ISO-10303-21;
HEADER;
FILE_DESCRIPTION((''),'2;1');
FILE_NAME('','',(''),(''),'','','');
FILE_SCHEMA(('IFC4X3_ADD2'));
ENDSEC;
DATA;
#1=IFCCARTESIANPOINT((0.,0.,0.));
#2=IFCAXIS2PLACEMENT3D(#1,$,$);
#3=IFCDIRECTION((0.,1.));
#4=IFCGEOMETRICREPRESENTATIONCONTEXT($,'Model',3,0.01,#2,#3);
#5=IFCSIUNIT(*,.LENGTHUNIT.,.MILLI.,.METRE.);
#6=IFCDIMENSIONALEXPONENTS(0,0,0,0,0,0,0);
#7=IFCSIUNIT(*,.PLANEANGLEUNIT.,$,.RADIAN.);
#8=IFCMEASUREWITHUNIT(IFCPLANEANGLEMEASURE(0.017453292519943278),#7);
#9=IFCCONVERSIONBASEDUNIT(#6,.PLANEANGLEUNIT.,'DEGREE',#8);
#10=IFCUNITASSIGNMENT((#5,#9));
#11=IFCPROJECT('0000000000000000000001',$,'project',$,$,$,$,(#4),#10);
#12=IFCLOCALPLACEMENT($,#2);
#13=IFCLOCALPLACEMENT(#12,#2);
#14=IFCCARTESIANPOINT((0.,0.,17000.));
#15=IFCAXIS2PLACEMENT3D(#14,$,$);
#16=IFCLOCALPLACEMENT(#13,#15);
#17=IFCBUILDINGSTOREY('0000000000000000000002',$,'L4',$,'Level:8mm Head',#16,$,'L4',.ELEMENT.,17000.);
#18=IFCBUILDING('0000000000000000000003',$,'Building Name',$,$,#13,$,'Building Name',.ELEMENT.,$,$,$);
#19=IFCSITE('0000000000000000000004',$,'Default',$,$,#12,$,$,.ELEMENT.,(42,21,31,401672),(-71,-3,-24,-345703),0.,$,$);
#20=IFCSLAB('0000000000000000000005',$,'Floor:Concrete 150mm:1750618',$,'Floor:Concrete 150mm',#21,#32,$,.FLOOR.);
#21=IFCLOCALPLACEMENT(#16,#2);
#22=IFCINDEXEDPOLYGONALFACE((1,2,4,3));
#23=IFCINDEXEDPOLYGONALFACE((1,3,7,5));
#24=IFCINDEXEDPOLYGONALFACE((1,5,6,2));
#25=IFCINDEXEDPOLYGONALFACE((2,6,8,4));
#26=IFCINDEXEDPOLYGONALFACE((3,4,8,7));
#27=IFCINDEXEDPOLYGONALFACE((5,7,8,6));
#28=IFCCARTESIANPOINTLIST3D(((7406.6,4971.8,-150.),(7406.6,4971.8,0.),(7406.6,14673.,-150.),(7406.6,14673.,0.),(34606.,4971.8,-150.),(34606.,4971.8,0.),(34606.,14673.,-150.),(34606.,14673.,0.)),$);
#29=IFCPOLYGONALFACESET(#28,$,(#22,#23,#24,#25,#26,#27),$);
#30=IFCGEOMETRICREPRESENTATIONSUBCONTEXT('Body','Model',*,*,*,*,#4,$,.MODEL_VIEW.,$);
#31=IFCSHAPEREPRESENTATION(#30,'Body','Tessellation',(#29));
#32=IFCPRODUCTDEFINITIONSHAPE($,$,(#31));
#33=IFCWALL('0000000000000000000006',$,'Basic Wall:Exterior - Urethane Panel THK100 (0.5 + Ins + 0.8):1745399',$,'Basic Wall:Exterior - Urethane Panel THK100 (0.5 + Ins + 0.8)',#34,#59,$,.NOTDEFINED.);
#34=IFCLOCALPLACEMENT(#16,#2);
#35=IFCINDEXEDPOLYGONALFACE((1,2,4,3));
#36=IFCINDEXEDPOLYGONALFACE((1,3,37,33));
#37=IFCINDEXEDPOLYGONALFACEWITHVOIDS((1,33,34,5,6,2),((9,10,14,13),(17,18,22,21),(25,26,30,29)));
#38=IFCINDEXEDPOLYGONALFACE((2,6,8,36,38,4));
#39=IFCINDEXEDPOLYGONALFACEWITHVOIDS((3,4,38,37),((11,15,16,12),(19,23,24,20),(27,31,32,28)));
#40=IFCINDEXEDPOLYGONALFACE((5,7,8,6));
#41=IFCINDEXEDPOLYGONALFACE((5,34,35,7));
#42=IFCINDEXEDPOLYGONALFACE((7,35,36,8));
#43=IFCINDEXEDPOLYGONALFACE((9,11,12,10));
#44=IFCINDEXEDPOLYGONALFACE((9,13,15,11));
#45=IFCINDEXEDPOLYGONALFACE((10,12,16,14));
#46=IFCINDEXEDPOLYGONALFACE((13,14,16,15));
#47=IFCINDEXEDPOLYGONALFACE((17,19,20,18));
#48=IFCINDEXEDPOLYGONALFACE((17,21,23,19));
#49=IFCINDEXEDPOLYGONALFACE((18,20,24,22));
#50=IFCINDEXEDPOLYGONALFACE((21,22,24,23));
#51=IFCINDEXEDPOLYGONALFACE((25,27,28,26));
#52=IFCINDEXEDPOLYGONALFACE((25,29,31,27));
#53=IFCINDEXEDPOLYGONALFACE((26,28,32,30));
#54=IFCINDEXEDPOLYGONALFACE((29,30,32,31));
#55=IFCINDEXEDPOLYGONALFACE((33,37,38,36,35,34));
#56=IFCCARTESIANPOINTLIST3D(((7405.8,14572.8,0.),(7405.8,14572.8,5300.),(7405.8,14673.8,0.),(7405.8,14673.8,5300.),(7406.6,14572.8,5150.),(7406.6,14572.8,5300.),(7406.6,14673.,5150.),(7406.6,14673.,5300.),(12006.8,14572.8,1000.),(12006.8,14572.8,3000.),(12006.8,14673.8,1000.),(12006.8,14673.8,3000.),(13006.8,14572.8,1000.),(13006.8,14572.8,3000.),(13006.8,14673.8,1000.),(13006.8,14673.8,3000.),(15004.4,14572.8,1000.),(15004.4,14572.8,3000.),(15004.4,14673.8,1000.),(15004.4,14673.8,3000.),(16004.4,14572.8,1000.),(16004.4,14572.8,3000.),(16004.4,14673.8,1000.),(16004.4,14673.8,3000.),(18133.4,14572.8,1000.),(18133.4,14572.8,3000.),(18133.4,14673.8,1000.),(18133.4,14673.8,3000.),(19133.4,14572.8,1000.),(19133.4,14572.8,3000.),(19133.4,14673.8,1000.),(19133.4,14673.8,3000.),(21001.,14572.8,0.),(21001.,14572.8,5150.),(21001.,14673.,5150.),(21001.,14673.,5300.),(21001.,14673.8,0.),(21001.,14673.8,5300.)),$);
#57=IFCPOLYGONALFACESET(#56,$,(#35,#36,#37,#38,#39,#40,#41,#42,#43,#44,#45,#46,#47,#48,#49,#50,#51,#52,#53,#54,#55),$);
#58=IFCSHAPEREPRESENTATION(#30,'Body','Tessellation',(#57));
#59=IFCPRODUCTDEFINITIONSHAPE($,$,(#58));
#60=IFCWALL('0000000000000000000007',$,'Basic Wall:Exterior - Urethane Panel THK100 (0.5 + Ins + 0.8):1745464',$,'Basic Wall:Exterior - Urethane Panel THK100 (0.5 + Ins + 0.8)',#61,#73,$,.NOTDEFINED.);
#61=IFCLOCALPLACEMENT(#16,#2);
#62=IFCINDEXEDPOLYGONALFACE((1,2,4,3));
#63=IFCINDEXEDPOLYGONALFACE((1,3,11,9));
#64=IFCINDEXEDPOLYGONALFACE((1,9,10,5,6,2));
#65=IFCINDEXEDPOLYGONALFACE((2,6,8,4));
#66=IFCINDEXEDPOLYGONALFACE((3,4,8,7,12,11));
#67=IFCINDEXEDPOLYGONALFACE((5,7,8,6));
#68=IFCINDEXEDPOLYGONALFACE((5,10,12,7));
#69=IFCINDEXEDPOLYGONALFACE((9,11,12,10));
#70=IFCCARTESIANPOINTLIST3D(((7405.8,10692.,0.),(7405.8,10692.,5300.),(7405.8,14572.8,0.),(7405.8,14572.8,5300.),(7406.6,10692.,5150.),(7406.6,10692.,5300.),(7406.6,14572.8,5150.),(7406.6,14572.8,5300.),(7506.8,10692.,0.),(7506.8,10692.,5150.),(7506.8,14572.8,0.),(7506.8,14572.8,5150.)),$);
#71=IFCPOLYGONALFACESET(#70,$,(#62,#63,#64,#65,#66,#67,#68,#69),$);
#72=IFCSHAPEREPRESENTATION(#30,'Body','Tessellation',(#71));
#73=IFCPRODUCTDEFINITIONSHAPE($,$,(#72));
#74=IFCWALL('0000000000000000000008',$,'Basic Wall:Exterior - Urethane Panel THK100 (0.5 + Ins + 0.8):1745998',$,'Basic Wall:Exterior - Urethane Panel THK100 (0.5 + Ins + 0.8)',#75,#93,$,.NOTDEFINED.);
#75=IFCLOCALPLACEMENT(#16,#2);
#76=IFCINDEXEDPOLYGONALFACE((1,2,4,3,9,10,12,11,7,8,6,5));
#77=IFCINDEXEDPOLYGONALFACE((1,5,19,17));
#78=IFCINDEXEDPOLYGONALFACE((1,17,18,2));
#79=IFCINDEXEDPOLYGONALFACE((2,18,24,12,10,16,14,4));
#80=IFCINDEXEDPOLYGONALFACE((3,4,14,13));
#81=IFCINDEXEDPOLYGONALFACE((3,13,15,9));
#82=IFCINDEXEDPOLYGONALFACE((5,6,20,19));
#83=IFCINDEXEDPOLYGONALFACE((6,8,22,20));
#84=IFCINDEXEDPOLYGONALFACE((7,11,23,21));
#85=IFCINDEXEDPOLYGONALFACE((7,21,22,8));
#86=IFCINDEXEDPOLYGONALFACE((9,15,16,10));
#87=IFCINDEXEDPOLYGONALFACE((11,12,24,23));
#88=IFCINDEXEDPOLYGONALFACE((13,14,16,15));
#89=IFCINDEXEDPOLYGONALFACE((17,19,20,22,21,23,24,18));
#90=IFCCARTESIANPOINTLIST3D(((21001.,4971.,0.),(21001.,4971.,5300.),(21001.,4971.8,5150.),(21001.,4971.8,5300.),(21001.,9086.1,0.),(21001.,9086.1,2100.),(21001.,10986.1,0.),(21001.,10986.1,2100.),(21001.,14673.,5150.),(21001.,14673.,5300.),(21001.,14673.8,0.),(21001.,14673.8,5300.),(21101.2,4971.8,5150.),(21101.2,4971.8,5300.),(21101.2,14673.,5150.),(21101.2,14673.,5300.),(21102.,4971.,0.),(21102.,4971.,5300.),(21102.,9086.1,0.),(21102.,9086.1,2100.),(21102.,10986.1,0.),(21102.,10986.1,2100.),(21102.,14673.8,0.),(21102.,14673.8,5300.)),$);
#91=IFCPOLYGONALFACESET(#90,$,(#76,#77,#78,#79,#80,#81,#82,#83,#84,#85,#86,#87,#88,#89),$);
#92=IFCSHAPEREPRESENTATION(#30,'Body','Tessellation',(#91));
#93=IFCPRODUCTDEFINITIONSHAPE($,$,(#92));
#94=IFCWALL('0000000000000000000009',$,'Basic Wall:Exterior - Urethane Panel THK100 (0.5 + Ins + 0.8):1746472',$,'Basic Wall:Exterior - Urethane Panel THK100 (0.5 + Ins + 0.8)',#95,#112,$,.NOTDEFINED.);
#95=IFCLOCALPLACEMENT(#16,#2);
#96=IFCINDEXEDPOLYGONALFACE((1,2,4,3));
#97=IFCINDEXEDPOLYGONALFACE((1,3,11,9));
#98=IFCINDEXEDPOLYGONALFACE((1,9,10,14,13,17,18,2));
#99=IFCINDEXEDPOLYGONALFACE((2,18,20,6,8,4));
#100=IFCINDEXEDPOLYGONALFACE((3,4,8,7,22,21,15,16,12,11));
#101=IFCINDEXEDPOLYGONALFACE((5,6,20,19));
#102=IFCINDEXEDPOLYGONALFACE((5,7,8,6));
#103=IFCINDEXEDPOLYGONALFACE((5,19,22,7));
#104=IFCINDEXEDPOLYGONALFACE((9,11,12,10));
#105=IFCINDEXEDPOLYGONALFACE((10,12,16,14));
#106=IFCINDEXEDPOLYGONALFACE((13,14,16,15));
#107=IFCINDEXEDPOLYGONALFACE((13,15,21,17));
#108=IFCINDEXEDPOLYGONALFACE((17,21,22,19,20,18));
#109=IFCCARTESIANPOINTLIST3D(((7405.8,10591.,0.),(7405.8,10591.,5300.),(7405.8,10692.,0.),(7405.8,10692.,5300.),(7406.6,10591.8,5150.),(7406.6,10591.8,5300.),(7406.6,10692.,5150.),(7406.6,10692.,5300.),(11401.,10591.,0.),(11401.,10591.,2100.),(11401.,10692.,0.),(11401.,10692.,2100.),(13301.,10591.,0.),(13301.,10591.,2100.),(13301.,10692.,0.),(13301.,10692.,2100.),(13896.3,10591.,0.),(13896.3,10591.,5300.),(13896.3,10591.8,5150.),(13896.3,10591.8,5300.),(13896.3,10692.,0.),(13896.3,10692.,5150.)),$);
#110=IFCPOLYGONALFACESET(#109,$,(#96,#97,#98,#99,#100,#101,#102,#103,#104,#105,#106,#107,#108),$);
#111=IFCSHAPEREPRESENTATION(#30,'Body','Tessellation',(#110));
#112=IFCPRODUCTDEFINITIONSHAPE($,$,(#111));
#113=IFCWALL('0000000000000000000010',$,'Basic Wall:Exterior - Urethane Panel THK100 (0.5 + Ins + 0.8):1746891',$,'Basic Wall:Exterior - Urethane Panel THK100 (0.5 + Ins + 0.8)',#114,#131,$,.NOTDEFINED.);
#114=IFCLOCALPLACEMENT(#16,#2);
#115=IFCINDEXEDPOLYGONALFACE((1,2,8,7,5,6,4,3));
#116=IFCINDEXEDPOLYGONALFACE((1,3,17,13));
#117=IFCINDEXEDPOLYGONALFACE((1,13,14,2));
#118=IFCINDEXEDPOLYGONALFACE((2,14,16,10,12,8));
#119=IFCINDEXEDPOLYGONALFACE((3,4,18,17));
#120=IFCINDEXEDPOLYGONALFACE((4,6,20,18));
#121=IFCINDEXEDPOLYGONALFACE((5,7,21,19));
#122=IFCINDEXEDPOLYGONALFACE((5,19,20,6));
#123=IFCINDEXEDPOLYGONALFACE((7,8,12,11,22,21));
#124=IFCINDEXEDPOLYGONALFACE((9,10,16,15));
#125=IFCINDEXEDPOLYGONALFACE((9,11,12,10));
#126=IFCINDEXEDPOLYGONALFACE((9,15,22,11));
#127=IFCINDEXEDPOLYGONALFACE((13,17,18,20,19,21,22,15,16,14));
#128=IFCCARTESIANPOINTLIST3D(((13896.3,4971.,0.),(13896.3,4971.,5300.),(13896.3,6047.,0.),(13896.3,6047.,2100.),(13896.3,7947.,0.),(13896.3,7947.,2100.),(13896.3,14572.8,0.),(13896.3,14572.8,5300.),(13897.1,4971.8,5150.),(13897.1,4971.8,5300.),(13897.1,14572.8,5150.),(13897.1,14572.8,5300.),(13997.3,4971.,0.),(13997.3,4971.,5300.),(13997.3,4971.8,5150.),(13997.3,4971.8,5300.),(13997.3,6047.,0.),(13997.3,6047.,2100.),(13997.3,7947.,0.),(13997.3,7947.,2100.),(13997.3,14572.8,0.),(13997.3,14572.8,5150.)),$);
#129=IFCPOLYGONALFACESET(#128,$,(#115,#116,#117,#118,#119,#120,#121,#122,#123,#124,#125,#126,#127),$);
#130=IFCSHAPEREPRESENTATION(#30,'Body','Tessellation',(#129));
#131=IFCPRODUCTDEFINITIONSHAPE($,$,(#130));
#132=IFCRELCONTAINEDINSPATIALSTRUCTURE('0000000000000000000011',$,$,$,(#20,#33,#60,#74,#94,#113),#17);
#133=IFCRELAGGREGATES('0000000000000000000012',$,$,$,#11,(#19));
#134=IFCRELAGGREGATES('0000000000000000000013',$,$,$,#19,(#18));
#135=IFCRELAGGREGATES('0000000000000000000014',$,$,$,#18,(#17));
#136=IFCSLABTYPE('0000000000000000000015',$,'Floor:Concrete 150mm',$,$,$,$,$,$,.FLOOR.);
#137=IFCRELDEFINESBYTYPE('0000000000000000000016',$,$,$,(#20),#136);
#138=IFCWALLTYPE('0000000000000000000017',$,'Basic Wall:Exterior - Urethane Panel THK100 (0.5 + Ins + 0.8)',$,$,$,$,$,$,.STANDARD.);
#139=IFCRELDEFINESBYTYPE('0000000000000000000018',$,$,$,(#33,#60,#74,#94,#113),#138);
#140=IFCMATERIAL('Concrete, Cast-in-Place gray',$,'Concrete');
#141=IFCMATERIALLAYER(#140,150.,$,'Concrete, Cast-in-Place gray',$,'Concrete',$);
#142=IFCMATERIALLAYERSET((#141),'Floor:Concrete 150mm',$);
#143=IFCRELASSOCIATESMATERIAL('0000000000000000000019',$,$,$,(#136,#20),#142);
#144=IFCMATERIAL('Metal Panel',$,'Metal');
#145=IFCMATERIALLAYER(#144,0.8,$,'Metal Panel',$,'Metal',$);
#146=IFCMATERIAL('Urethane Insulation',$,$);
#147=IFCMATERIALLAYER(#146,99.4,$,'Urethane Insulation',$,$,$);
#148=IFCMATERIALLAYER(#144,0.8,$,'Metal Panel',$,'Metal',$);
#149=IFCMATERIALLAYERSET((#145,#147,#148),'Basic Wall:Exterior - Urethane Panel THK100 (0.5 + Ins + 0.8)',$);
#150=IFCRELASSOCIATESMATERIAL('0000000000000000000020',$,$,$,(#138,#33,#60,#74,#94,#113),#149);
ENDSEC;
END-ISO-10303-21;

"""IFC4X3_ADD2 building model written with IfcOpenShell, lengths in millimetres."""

from ifc_helpers import new_model, entity, si_unit, converted_unit, direction, frame, frame_2d, origin, place, context, subcontext, project, spatial, polyline, rectangle, extrude, clip, bounded_halfspace, material, layer, layer_set, layer_usage, type_object, element, save


model = new_model("IFC4X3_ADD2")

# Units and contexts
model_context = context("Model", 3, precision=0.01, world=origin(), true_north=direction((0.0, 1.0)))
body_context = subcontext(model_context, "Body", "Model", "MODEL_VIEW")
ifc_project = project(units=[si_unit("LENGTHUNIT", "METRE", prefix="MILLI"), converted_unit("PLANEANGLEUNIT", "DEGREE", entity("IfcPlaneAngleMeasure", 0.017453292519943278), si_unit("PLANEANGLEUNIT", "RADIAN"), dimensions=[0, 0, 0, 0, 0, 0, 0])], contexts=[model_context])

# Site, building, storey
site_placement = place(None, origin())
site = spatial("IfcSite", under=ifc_project, at=site_placement, Name="Default", CompositionType="ELEMENT", RefLatitude=(42, 21, 31, 401672), RefLongitude=(-71, -3, -24, -345703), RefElevation=0.0)
building_placement = place(site_placement, origin())
building = spatial("IfcBuilding", under=site, at=building_placement, Name="Building Name", LongName="Building Name", CompositionType="ELEMENT")
storey_placement = place(building_placement, frame((0.0, 0.0, 17000.0)))
storey = spatial("IfcBuildingStorey", under=building, at=storey_placement, Name="L4", ObjectType="Level:8mm Head", LongName="L4", CompositionType="ELEMENT", Elevation=17000.0)

# Slab
ifc_material_1 = material(Name="Concrete, Cast-in-Place gray", Category="Concrete")
ifc_layer_1 = layer(ifc_material_1, 150.0, Name="Concrete, Cast-in-Place gray", Category="Concrete")
ifc_layer_set_1 = layer_set([ifc_layer_1], Name="Floor:Concrete 150mm")
ifc_layer_usage = layer_usage(ifc_layer_set_1, "AXIS3", "POSITIVE", 0.0)
slab_type = type_object("IfcSlabType", Name="Floor:Concrete 150mm", PredefinedType="FLOOR", material=ifc_layer_set_1)
slab_placement = place(storey_placement, origin())
element("IfcSlab", 1, at=slab_placement, inside=storey, type_object=slab_type, material=ifc_layer_usage, Name="Floor:Concrete 150mm:1750618", ObjectType="Floor:Concrete 150mm", PredefinedType="FLOOR", context=body_context, shape_type="SweptSolid", body=[
    extrude(rectangle(XDim=9701.2, YDim=27199.4, at=frame_2d((0.0, 0.0), x_axis=(1.0, 0.0))), frame((21006.3, 9822.4, 0.0), z_axis=(0.0, 0.0, -1.0), x_axis=(0.0, 1.0, 0.0)), (0.0, 0.0, 1.0), 150.0),
])

# Wall, openings
ifc_material_2 = material(Name="Metal Panel", Category="Metal")
ifc_layer_2 = layer(ifc_material_2, 0.8, Name="Metal Panel", Category="Metal")
ifc_material_3 = material(Name="Urethane Insulation")
ifc_layer_3 = layer(ifc_material_3, 99.4, Name="Urethane Insulation")
ifc_layer_4 = layer(ifc_material_2, 0.8, Name="Metal Panel", Category="Metal")
ifc_layer_set_2 = layer_set([ifc_layer_2, ifc_layer_3, ifc_layer_4], Name="Basic Wall:Exterior - Urethane Panel THK100 (0.5 + Ins + 0.8)")
wall_type = type_object("IfcWallType", Name="Basic Wall:Exterior - Urethane Panel THK100 (0.5 + Ins + 0.8)", PredefinedType="STANDARD", material=ifc_layer_set_2)
wall_1_placement = place(storey_placement, frame((7405.8, 14623.3, 0.0)))
wall_1 = element("IfcWall", 2, at=wall_1_placement, inside=storey, type_object=wall_type, material=ifc_layer_set_2, Name="Basic Wall:Exterior - Urethane Panel THK100 (0.5 + Ins + 0.8):1745399", ObjectType="Basic Wall:Exterior - Urethane Panel THK100 (0.5 + Ins + 0.8)", PredefinedType="NOTDEFINED", context=body_context, shape_type="Clipping", body=[
    clip(extrude(rectangle(XDim=13595.2, YDim=101.0, at=frame_2d((6797.6, 0.0), x_axis=(-1.0, 0.0))), origin(), (0.0, 0.0, 1.0), 5300.0), bounded_halfspace(frame((0.8, -50.5, 5150.0), z_axis=(0.0, 0.0, -1.0), x_axis=(0.0, 1.0, 0.0)), True, frame((0.8, -50.5, 5150.0)), polyline([(0.0, 0.0), (100.2, 0.0), (6490.5, 0.0), (6590.7, 0.0), (13594.4, 0.0), (13594.4, 100.2), (0.0, 100.2), (0.0, 0.0)]))),
])
opening_1_placement = place(wall_1_placement, frame((10727.6, -50.5, 1000.0)))
element("IfcOpeningElement", 3, at=opening_1_placement, cuts=wall_1, PredefinedType="OPENING", context=body_context, shape_type="SweptSolid", body=[
    extrude(rectangle(XDim=2000.0, YDim=1000.0, at=frame_2d((1000.0, 500.0), x_axis=(-1.0, 0.0))), frame((0.0, 0.0, 0.0), z_axis=(0.0, 1.0, 0.0), x_axis=(0.0, 0.0, 1.0)), (0.0, 0.0, 1.0), 101.0),
])
opening_2_placement = place(wall_1_placement, frame((7598.6, -50.5, 1000.0)))
element("IfcOpeningElement", 4, at=opening_2_placement, cuts=wall_1, PredefinedType="OPENING", context=body_context, shape_type="SweptSolid", body=[
    extrude(rectangle(XDim=2000.0, YDim=1000.0, at=frame_2d((1000.0, 500.0), x_axis=(-1.0, 0.0))), frame((0.0, 0.0, 0.0), z_axis=(0.0, 1.0, 0.0), x_axis=(0.0, 0.0, 1.0)), (0.0, 0.0, 1.0), 101.0),
])
opening_3_placement = place(wall_1_placement, frame((4601.0, -50.5, 1000.0)))
element("IfcOpeningElement", 5, at=opening_3_placement, cuts=wall_1, PredefinedType="OPENING", context=body_context, shape_type="SweptSolid", body=[
    extrude(rectangle(XDim=2000.0, YDim=1000.0, at=frame_2d((1000.0, 500.0), x_axis=(-1.0, 0.0))), frame((0.0, 0.0, 0.0), z_axis=(0.0, 1.0, 0.0), x_axis=(0.0, 0.0, 1.0)), (0.0, 0.0, 1.0), 101.0),
])

# Wall
wall_2_placement = place(storey_placement, frame((7456.3, 14572.8, 0.0), z_axis=(0.0, 0.0, 1.0), x_axis=(0.0, -1.0, 0.0)))
element("IfcWall", 6, at=wall_2_placement, inside=storey, type_object=wall_type, material=ifc_layer_set_2, Name="Basic Wall:Exterior - Urethane Panel THK100 (0.5 + Ins + 0.8):1745464", ObjectType="Basic Wall:Exterior - Urethane Panel THK100 (0.5 + Ins + 0.8)", PredefinedType="NOTDEFINED", context=body_context, shape_type="Clipping", body=[
    clip(extrude(rectangle(XDim=3880.8, YDim=101.0, at=frame_2d((1940.4, 0.0), x_axis=(-1.0, 0.0))), origin(), (0.0, 0.0, 1.0), 5300.0), bounded_halfspace(frame((3880.8, -49.7, 5150.0), z_axis=(0.0, 0.0, -1.0), x_axis=(-1.0, 0.0, 0.0)), True, frame((3880.8, -49.7, 5150.0)), polyline([(0.0, 0.0), (0.0, 100.2), (-3880.8, 100.2), (-3880.8, 0.0), (0.0, 0.0)]))),
])

# Walls, openings
wall_3_placement = place(storey_placement, frame((21051.5, 14673.8, 0.0), z_axis=(0.0, 0.0, 1.0), x_axis=(0.0, -1.0, 0.0)))
wall_3 = element("IfcWall", 7, at=wall_3_placement, inside=storey, type_object=wall_type, material=ifc_layer_set_2, Name="Basic Wall:Exterior - Urethane Panel THK100 (0.5 + Ins + 0.8):1745998", ObjectType="Basic Wall:Exterior - Urethane Panel THK100 (0.5 + Ins + 0.8)", PredefinedType="NOTDEFINED", context=body_context, shape_type="Clipping", body=[
    clip(extrude(rectangle(XDim=9702.8, YDim=101.0, at=frame_2d((4851.4, 0.0), x_axis=(-1.0, 0.0))), origin(), (0.0, 0.0, 1.0), 5300.0), bounded_halfspace(frame((0.8, -50.5, 5150.0), z_axis=(0.0, 0.0, -1.0), x_axis=(-1.0, 0.0, 0.0)), True, frame((0.8, -50.5, 5150.0)), polyline([(0.0, 0.0), (100.2, 0.0), (6005.9, 0.0), (6106.9, 0.0), (9601.0, 0.0), (9701.2, 0.0), (9701.2, 100.2), (0.0, 100.2), (0.0, 0.0)]))),
])
opening_4_placement = place(wall_3_placement, frame((3687.7, -50.5, 0.0)))
element("IfcOpeningElement", 8, at=opening_4_placement, cuts=wall_3, PredefinedType="OPENING", context=body_context, shape_type="SweptSolid", body=[
    extrude(rectangle(XDim=2100.0, YDim=1900.0, at=frame_2d((1050.0, 950.0), x_axis=(1.0, 0.0))), frame((0.0, 0.0, 0.0), z_axis=(0.0, 1.0, 0.0), x_axis=(0.0, 0.0, 1.0)), (0.0, 0.0, 1.0), 101.0),
])
wall_4_placement = place(storey_placement, frame((7405.8, 10641.5, 0.0)))
wall_4 = element("IfcWall", 9, at=wall_4_placement, inside=storey, type_object=wall_type, material=ifc_layer_set_2, Name="Basic Wall:Exterior - Urethane Panel THK100 (0.5 + Ins + 0.8):1746472", ObjectType="Basic Wall:Exterior - Urethane Panel THK100 (0.5 + Ins + 0.8)", PredefinedType="NOTDEFINED", context=body_context, shape_type="Clipping", body=[
    clip(extrude(rectangle(XDim=6490.5, YDim=101.0, at=frame_2d((3245.2, 0.0), x_axis=(-1.0, 0.0))), origin(), (0.0, 0.0, 1.0), 5300.0), bounded_halfspace(frame((6490.5, -49.7, 5150.0), z_axis=(0.0, 0.0, -1.0), x_axis=(0.0, 1.0, 0.0)), True, frame((6490.5, -49.7, 5150.0)), polyline([(0.0, 0.0), (0.0, 100.2), (-6389.5, 100.2), (-6489.7, 100.2), (-6489.7, 0.0), (0.0, 0.0)]))),
])
opening_5_placement = place(wall_4_placement, frame((5895.2, 50.5, 0.0)))
element("IfcOpeningElement", 10, at=opening_5_placement, cuts=wall_4, PredefinedType="OPENING", context=body_context, shape_type="SweptSolid", body=[
    extrude(rectangle(XDim=2100.0, YDim=1900.0, at=frame_2d((1050.0, 950.0), x_axis=(1.0, 0.0))), frame((0.0, 0.0, 0.0), z_axis=(0.0, -1.0, 0.0), x_axis=(0.0, 0.0, 1.0)), (0.0, 0.0, 1.0), 101.0),
])
wall_5_placement = place(storey_placement, frame((13946.8, 14572.8, 0.0), z_axis=(0.0, 0.0, 1.0), x_axis=(0.0, -1.0, 0.0)))
wall_5 = element("IfcWall", 11, at=wall_5_placement, inside=storey, type_object=wall_type, material=ifc_layer_set_2, Name="Basic Wall:Exterior - Urethane Panel THK100 (0.5 + Ins + 0.8):1746891", ObjectType="Basic Wall:Exterior - Urethane Panel THK100 (0.5 + Ins + 0.8)", PredefinedType="NOTDEFINED", context=body_context, shape_type="Clipping", body=[
    clip(extrude(rectangle(XDim=9601.8, YDim=101.0, at=frame_2d((4800.9, 0.0), x_axis=(-1.0, 0.0))), origin(), (0.0, 0.0, 1.0), 5300.0), bounded_halfspace(frame((9601.0, -49.7, 5150.0), z_axis=(0.0, 0.0, -1.0), x_axis=(-1.0, 0.0, 0.0)), True, frame((9601.0, -49.7, 5150.0)), polyline([(0.0, 0.0), (0.0, 100.2), (-100.2, 100.2), (-3594.2, 100.2), (-3695.2, 100.2), (-9601.0, 100.2), (-9601.0, 0.0), (-5620.0, 0.0), (0.0, 0.0)]))),
])
opening_6_placement = place(wall_5_placement, frame((8525.8, 50.5, 0.0)))
element("IfcOpeningElement", 12, at=opening_6_placement, cuts=wall_5, PredefinedType="OPENING", context=body_context, shape_type="SweptSolid", body=[
    extrude(rectangle(XDim=2100.0, YDim=1900.0, at=frame_2d((1050.0, 950.0), x_axis=(1.0, 0.0))), frame((0.0, 0.0, 0.0), z_axis=(0.0, -1.0, 0.0), x_axis=(0.0, 0.0, 1.0)), (0.0, 0.0, 1.0), 101.0),
])

save(model, "model.ifc")
